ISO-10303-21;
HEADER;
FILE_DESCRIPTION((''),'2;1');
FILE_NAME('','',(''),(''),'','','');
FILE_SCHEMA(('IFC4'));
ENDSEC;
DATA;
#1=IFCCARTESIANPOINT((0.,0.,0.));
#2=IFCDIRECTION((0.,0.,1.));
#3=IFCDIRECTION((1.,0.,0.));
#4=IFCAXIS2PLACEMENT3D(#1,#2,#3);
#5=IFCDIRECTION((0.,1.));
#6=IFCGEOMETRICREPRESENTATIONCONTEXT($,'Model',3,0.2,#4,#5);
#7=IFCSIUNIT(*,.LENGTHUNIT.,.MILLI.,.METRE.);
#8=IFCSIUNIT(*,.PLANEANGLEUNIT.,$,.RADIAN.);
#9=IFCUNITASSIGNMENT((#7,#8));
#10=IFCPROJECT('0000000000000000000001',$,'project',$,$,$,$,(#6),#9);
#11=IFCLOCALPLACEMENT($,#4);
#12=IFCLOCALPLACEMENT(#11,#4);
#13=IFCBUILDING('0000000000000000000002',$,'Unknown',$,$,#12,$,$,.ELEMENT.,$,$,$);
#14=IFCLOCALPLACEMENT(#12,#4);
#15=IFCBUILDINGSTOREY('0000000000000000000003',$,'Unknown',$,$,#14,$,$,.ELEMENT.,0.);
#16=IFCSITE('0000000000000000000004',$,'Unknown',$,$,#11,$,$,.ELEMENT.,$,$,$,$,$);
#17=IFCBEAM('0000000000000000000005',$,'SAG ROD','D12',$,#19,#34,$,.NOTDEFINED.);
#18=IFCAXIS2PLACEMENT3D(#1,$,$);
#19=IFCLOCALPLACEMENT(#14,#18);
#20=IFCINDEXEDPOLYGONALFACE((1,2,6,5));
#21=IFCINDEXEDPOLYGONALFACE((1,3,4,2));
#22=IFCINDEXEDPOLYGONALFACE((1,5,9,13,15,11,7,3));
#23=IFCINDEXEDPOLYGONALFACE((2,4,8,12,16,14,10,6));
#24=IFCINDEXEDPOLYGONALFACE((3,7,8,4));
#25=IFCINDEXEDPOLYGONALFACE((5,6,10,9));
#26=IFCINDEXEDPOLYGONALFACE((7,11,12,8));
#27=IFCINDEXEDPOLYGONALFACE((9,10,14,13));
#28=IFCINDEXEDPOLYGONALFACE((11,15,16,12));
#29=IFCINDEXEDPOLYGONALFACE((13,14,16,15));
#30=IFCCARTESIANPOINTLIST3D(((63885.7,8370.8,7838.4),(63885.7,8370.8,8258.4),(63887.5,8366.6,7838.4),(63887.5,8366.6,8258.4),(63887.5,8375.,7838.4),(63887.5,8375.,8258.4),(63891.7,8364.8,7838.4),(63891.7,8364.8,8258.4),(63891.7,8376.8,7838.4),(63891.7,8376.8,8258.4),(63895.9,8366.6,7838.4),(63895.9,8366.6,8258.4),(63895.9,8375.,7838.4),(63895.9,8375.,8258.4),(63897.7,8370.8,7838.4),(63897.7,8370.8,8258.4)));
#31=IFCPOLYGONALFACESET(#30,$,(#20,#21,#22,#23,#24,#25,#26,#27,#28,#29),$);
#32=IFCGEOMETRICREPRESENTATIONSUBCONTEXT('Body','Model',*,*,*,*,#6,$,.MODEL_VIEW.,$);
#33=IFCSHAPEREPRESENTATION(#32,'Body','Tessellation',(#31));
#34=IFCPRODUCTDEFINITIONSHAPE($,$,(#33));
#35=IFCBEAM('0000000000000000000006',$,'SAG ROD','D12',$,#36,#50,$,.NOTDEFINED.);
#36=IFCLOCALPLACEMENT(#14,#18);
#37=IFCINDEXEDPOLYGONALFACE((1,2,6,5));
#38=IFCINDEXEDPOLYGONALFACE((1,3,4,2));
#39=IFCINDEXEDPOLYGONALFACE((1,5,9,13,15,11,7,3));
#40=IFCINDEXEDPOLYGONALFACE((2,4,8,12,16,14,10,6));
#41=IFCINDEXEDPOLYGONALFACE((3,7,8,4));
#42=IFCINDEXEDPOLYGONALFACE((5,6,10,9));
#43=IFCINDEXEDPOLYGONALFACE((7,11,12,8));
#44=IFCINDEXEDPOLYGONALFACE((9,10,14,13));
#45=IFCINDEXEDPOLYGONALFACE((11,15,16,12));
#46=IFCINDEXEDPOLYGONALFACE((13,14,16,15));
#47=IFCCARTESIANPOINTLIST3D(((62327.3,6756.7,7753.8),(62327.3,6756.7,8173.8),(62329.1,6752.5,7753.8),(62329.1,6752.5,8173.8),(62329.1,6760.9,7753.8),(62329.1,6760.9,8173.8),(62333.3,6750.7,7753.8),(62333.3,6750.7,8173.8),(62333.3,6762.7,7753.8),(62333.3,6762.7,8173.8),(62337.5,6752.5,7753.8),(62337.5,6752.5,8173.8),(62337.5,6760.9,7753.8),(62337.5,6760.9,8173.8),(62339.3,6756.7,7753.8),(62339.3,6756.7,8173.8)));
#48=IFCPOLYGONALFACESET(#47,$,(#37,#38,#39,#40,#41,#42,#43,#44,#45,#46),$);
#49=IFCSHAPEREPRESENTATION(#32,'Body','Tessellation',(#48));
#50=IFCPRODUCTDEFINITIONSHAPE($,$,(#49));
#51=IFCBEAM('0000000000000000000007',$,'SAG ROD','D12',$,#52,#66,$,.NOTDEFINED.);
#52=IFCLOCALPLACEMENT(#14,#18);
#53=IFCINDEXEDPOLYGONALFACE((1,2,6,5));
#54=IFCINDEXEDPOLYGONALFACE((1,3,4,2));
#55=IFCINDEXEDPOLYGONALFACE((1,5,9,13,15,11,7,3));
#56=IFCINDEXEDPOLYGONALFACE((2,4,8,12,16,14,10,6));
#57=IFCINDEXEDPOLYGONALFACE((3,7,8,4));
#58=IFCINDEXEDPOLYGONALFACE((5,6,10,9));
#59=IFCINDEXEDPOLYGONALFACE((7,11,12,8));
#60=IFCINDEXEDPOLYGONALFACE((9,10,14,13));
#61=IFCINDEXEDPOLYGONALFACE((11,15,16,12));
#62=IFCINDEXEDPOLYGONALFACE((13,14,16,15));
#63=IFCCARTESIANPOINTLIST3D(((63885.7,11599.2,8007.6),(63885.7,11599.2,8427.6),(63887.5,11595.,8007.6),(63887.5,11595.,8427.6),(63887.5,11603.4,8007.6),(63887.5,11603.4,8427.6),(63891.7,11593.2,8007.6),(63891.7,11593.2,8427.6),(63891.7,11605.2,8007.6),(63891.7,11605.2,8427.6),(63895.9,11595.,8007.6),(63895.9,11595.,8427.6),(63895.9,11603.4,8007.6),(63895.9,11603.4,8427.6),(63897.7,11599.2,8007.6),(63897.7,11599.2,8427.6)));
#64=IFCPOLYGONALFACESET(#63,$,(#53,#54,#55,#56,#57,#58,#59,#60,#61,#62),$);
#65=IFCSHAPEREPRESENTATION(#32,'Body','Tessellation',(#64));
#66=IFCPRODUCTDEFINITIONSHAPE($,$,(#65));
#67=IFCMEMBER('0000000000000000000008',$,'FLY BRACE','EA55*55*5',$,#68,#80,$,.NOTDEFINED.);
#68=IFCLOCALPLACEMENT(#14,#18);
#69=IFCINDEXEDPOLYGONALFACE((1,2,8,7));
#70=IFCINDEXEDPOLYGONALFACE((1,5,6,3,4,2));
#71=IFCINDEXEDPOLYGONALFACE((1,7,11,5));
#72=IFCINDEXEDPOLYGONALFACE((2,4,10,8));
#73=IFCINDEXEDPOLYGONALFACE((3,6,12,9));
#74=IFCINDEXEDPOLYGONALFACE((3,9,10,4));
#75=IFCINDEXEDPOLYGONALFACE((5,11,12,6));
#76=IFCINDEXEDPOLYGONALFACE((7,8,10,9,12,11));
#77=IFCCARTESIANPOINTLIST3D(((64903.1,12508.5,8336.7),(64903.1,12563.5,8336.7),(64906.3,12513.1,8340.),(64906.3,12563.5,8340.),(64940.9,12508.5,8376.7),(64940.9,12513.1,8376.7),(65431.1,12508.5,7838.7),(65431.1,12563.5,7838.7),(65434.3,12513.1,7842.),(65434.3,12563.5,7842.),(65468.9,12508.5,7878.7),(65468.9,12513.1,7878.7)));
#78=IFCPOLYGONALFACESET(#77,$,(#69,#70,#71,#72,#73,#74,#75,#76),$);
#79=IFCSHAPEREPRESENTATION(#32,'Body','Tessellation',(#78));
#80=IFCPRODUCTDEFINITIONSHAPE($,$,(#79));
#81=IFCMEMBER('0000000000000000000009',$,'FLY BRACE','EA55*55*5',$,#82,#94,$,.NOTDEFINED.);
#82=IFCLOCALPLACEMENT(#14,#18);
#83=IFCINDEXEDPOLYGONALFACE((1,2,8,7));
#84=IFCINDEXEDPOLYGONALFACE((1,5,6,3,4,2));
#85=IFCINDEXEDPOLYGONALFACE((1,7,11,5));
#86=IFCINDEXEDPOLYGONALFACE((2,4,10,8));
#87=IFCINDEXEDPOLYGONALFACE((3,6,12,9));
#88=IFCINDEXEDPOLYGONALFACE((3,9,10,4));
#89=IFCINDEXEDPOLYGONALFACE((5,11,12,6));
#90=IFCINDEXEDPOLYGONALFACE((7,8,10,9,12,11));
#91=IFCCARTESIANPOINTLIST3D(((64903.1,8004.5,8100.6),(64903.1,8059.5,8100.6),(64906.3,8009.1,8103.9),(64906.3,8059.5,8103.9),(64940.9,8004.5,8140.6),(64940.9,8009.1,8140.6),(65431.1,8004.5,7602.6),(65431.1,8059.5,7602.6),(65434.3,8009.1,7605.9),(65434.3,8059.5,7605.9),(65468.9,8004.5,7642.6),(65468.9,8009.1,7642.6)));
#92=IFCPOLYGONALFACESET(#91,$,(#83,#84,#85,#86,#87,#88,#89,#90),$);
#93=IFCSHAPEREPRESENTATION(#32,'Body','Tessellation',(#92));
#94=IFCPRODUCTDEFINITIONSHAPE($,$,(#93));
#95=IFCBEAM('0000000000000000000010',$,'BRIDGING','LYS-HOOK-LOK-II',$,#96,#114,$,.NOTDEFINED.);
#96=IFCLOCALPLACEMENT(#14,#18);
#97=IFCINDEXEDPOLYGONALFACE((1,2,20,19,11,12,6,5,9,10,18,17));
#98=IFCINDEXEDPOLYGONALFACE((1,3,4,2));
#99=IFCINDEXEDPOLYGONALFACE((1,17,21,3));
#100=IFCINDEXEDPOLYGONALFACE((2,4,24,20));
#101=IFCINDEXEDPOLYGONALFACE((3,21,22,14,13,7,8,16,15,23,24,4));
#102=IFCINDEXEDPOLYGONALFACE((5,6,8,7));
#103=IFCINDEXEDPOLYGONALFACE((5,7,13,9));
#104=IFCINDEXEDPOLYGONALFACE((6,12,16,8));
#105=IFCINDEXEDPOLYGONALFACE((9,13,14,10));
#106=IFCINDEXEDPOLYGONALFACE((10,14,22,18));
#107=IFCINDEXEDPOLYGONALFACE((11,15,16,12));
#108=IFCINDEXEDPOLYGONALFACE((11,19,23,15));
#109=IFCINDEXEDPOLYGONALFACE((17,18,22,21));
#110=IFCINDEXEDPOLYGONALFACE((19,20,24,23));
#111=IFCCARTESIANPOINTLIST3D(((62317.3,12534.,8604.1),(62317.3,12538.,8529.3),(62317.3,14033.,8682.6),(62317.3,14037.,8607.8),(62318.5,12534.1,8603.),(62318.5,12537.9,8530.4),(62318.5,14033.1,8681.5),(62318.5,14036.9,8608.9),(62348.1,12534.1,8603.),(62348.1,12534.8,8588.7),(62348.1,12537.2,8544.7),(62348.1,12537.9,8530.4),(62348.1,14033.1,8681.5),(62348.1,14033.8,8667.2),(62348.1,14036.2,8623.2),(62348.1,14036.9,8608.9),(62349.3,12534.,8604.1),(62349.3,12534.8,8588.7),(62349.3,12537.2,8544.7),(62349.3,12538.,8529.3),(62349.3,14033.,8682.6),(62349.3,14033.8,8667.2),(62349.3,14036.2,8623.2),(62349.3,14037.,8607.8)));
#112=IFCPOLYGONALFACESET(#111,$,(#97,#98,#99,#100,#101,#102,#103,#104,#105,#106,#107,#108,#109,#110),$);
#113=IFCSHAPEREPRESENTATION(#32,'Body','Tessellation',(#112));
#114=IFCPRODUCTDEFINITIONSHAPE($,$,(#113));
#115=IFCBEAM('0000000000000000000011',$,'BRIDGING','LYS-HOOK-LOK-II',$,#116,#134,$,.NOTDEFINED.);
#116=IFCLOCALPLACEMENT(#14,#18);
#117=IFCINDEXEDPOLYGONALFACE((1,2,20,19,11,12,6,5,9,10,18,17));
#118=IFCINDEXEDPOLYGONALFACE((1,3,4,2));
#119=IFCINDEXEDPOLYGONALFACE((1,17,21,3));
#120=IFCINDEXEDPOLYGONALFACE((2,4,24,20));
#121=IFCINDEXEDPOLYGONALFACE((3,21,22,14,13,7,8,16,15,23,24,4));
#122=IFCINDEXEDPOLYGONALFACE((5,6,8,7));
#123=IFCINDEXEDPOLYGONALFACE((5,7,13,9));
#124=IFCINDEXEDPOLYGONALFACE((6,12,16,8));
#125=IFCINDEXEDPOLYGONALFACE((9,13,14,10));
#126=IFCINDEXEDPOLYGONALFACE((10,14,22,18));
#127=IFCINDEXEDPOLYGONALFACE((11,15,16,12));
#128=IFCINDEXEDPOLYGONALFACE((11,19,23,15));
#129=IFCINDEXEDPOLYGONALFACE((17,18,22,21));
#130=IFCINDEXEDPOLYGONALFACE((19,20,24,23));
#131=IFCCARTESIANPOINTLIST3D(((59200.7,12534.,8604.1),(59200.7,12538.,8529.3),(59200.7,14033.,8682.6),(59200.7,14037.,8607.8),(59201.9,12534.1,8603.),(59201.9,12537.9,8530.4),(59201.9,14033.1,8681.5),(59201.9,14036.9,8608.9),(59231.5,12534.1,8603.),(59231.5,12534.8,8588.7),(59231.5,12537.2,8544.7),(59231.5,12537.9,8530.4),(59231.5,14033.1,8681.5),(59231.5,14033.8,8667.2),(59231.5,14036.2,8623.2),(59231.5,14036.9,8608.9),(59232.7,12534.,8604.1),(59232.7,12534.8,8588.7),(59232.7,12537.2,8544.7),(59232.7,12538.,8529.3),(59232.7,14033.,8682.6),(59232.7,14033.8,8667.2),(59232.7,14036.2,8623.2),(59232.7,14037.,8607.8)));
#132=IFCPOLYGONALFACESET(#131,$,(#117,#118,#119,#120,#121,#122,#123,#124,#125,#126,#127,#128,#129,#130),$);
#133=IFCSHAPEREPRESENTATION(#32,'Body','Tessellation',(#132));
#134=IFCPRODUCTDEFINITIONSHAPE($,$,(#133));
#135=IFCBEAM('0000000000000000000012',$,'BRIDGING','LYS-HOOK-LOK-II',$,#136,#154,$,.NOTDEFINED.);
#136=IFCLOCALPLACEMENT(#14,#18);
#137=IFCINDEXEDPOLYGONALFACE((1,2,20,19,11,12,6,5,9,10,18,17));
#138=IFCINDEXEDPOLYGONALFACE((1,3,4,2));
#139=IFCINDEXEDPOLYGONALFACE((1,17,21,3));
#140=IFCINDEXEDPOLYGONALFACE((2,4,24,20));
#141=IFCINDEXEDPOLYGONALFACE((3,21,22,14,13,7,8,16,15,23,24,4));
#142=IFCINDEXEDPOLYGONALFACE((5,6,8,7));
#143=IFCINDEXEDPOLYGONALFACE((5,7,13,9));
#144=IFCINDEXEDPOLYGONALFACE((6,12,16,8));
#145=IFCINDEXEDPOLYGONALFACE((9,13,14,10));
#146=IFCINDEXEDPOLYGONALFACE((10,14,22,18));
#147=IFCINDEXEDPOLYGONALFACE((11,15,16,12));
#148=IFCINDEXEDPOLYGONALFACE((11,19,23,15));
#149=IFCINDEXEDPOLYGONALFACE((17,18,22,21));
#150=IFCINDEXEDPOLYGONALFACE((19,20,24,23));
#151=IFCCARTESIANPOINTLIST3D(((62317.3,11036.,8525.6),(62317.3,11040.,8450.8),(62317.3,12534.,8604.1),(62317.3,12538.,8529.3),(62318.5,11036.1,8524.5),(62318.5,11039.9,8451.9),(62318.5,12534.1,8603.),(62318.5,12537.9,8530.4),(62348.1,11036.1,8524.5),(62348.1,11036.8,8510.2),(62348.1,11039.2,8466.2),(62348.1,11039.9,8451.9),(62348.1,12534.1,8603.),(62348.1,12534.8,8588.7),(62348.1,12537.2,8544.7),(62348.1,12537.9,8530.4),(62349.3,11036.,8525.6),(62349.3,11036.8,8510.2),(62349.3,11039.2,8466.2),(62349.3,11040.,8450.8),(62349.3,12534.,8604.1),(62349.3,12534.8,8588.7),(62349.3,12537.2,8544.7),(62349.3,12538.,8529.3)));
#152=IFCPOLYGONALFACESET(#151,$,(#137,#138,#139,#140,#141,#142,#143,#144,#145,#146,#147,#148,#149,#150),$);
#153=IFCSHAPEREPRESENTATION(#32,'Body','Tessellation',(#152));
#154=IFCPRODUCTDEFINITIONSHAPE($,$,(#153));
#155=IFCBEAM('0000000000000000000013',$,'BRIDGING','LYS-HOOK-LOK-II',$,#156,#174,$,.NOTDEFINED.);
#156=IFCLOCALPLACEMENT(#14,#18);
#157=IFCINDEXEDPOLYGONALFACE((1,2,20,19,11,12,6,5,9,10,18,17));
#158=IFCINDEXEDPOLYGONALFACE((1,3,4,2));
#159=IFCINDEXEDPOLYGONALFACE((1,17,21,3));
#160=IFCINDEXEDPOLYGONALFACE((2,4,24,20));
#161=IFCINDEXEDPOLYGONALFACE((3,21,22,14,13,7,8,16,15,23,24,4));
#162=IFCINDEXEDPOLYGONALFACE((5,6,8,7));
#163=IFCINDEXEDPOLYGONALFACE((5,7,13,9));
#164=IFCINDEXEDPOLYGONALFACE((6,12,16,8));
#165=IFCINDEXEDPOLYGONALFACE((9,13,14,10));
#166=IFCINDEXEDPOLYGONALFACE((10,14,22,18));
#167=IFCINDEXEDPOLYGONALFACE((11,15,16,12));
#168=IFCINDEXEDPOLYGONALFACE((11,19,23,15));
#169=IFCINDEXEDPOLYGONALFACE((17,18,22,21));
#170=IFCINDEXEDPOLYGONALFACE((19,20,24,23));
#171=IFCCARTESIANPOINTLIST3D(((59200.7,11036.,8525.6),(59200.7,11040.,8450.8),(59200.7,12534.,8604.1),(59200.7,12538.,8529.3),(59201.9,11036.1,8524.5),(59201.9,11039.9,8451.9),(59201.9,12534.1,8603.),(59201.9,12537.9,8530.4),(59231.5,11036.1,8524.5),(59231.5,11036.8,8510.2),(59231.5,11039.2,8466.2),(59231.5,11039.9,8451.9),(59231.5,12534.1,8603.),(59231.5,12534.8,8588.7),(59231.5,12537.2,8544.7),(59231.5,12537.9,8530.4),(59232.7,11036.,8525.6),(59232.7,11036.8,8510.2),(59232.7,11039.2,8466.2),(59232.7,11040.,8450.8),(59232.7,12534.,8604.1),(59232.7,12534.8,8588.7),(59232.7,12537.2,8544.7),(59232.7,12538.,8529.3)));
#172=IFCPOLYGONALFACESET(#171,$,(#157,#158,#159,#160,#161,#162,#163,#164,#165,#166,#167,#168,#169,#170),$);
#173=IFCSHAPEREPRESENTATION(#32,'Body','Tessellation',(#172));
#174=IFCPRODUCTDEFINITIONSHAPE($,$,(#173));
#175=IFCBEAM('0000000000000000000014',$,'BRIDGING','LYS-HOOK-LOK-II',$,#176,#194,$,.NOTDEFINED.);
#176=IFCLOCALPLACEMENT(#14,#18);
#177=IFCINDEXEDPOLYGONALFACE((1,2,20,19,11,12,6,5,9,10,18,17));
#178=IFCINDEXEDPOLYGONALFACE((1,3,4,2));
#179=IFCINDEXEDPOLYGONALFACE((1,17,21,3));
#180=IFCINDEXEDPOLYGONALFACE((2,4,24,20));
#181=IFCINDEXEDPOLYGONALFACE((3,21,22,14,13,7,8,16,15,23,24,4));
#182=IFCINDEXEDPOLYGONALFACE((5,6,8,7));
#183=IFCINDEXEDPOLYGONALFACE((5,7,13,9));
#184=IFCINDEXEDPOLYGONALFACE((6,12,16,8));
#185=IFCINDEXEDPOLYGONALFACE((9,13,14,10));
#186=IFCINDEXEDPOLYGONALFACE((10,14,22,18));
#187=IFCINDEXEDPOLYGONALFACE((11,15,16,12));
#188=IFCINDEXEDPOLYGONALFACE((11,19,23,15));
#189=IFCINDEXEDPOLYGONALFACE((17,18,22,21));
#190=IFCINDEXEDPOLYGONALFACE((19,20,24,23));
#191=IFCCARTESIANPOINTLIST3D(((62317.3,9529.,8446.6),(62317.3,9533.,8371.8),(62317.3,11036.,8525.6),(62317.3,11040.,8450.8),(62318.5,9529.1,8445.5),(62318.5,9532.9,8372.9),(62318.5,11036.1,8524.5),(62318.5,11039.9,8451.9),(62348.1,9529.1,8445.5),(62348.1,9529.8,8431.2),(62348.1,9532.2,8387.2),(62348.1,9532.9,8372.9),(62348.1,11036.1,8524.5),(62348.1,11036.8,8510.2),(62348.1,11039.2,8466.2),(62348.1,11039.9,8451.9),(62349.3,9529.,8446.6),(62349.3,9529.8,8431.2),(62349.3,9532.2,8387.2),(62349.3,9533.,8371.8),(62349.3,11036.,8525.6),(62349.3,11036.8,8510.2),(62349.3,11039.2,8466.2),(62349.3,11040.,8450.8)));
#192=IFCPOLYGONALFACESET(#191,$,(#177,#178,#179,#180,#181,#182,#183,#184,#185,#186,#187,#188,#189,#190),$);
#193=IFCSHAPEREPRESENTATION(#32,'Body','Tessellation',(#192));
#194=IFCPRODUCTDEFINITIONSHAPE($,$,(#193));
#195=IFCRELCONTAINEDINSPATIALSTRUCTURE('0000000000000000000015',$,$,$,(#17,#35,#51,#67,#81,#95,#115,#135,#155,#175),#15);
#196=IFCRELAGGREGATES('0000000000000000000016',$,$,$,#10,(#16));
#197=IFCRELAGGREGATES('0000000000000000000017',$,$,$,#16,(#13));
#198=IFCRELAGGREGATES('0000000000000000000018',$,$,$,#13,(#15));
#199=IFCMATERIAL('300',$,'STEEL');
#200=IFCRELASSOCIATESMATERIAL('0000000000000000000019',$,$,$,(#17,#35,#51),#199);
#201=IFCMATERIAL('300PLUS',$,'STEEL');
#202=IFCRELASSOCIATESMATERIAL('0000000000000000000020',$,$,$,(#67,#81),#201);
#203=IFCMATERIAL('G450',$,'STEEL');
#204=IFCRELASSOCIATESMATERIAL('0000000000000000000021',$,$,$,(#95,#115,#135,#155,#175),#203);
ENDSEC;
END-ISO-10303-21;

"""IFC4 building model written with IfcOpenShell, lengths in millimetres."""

from ifc_helpers import new_model, si_unit, direction, frame, origin_with_axes, place, context, subcontext, project, spatial, line, indexed_curve, outline, extrude, material, element, save


model = new_model("IFC4")

# Units and contexts
model_context = context("Model", 3, precision=0.2, world=origin_with_axes(), true_north=direction((0.0, 1.0)))
body_context = subcontext(model_context, "Body", "Model", "MODEL_VIEW")
ifc_project = project(units=[si_unit("LENGTHUNIT", "METRE", prefix="MILLI"), si_unit("PLANEANGLEUNIT", "RADIAN")], contexts=[model_context])

# Site, building, storey
site_placement = place(None, origin_with_axes())
site = spatial("IfcSite", under=ifc_project, at=site_placement, Name="Unknown", CompositionType="ELEMENT")
building_placement = place(site_placement, origin_with_axes())
building = spatial("IfcBuilding", under=site, at=building_placement, Name="Unknown", CompositionType="ELEMENT")
storey_placement = place(building_placement, origin_with_axes())
storey = spatial("IfcBuildingStorey", under=building, at=storey_placement, Name="Unknown", CompositionType="ELEMENT", Elevation=0.0)

# Beams
ifc_material_1 = material(Name="300", Category="STEEL")
for number, where, z_axis, x_axis, name in (
    (1, (63891.7, 8370.8, 8258.4), (1.0, 0.0, 0.0), (0.0, 0.0, -1.0), "SAG ROD"),
    (2, (62333.3, 6756.7, 8173.8), (1.0, 0.0, 0.0), (0.0, 0.0, -1.0), "SAG ROD"),
    (3, (63891.7, 11599.2, 8427.6), (1.0, 0.0, 0.0), (0.0, 0.0, -1.0), "SAG ROD"),
):
    element("IfcBeam", number, at=place(storey_placement, frame(where, z_axis=z_axis, x_axis=x_axis)), inside=storey, material=ifc_material_1, Name=name, Description="D12", PredefinedType="NOTDEFINED", context=body_context, shape_type="SolidModel", body=[
        extrude(outline(indexed_curve([(6.0, 0.0), (4.2, 4.2), (0.0, 6.0), (-4.2, 4.2), (-6.0, 0.0), (-4.2, -4.2), (0.0, -6.0), (4.2, -4.2)], segments=[line(1, 2, 3, 4, 5, 6, 7, 8, 1)])), frame((0.0, 0.0, 0.0), z_axis=(-1.0, 0.0, 0.0), x_axis=(0.0, 0.0, 1.0)), (0.0, 0.0, -1.0), 420.0),
    ])

# Members
ifc_material_2 = material(Name="300PLUS", Category="STEEL")
for number, where, z_axis, x_axis, name in (
    (4, (64922.0, 12536.0, 8356.7), (0.686138, 0.0, 0.727472), (0.727472, 0.0, -0.686138), "FLY BRACE"),
    (5, (64922.0, 8032.0, 8120.6), (0.686138, 0.0, 0.727472), (0.727472, 0.0, -0.686138), "FLY BRACE"),
):
    element("IfcMember", number, at=place(storey_placement, frame(where, z_axis=z_axis, x_axis=x_axis)), inside=storey, material=ifc_material_2, Name=name, Description="EA55*55*5", PredefinedType="NOTDEFINED", context=body_context, shape_type="SolidModel", body=[
        extrude(outline(indexed_curve([(-27.5, -27.5), (27.5, -27.5), (27.5, -22.9), (-22.9, -22.9), (-22.9, 27.5), (-27.5, 27.5)], segments=[line(1, 2, 3, 4, 5, 6, 1)])), frame((0.0, 0.0, 0.0), z_axis=(-1.0, 0.0, 0.0), x_axis=(0.0, 0.0, 1.0)), (0.0, 0.0, -1.0), 725.8),
    ])

# Beams
ifc_material_3 = material(Name="G450", Category="STEEL")
for number, where, z_axis, x_axis, name in (
    (6, (62333.3, 12536.0, 8566.7), (1.0, 0.0, 0.0), (0.0, 0.998632, 0.052297), "BRIDGING"),
    (7, (59216.7, 12536.0, 8566.7), (1.0, 0.0, 0.0), (0.0, 0.998632, 0.052297), "BRIDGING"),
):
    element("IfcBeam", number, at=place(storey_placement, frame(where, z_axis=z_axis, x_axis=x_axis)), inside=storey, material=ifc_material_3, Name=name, Description="LYS-HOOK-LOK-II", PredefinedType="NOTDEFINED", context=body_context, shape_type="SolidModel", body=[
        extrude(outline(indexed_curve([(16.0, -37.5), (16.0, -22.0), (14.8, -22.0), (14.8, -36.3), (-14.8, -36.3), (-14.8, 36.3), (14.8, 36.3), (14.8, 22.0), (16.0, 22.0), (16.0, 37.5), (-16.0, 37.5), (-16.0, -37.5)], segments=[line(1, 2, 3, 4, 5, 6, 7, 8, 9, 10, 11, 12, 1)])), frame((0.0, 0.0, 0.0), z_axis=(-1.0, 0.0, 0.0), x_axis=(0.0, 0.0, 1.0)), (0.0, 0.0, -1.0), 1501.1),
    ])
for number, where, z_axis, x_axis, name in (
    (8, (62333.3, 11038.0, 8488.2), (1.0, 0.0, 0.0), (0.0, 0.99863, 0.052331), "BRIDGING"),
    (9, (59216.7, 11038.0, 8488.2), (1.0, 0.0, 0.0), (0.0, 0.99863, 0.052331), "BRIDGING"),
):
    element("IfcBeam", number, at=place(storey_placement, frame(where, z_axis=z_axis, x_axis=x_axis)), inside=storey, material=ifc_material_3, Name=name, Description="LYS-HOOK-LOK-II", PredefinedType="NOTDEFINED", context=body_context, shape_type="SolidModel", body=[
        extrude(outline(indexed_curve([(16.0, -37.5), (16.0, -22.0), (14.8, -22.0), (14.8, -36.3), (-14.8, -36.3), (-14.8, 36.3), (14.8, 36.3), (14.8, 22.0), (16.0, 22.0), (16.0, 37.5), (-16.0, 37.5), (-16.0, -37.5)], segments=[line(1, 2, 3, 4, 5, 6, 7, 8, 9, 10, 11, 12, 1)])), frame((0.0, 0.0, 0.0), z_axis=(-1.0, 0.0, 0.0), x_axis=(0.0, 0.0, 1.0)), (0.0, 0.0, -1.0), 1500.1),
    ])
for number, where, z_axis, x_axis, name in (
    (10, (62333.3, 9531.0, 8409.2), (1.0, 0.0, 0.0), (0.0, 0.998629, 0.05235), "BRIDGING"),
):
    element("IfcBeam", number, at=place(storey_placement, frame(where, z_axis=z_axis, x_axis=x_axis)), inside=storey, material=ifc_material_3, Name=name, Description="LYS-HOOK-LOK-II", PredefinedType="NOTDEFINED", context=body_context, shape_type="SolidModel", body=[
        extrude(outline(indexed_curve([(16.0, -37.5), (16.0, -22.0), (14.8, -22.0), (14.8, -36.3), (-14.8, -36.3), (-14.8, 36.3), (14.8, 36.3), (14.8, 22.0), (16.0, 22.0), (16.0, 37.5), (-16.0, 37.5), (-16.0, -37.5)], segments=[line(1, 2, 3, 4, 5, 6, 7, 8, 9, 10, 11, 12, 1)])), frame((0.0, 0.0, 0.0), z_axis=(-1.0, 0.0, 0.0), x_axis=(0.0, 0.0, 1.0)), (0.0, 0.0, -1.0), 1509.1),
    ])

save(model, "model.ifc")
